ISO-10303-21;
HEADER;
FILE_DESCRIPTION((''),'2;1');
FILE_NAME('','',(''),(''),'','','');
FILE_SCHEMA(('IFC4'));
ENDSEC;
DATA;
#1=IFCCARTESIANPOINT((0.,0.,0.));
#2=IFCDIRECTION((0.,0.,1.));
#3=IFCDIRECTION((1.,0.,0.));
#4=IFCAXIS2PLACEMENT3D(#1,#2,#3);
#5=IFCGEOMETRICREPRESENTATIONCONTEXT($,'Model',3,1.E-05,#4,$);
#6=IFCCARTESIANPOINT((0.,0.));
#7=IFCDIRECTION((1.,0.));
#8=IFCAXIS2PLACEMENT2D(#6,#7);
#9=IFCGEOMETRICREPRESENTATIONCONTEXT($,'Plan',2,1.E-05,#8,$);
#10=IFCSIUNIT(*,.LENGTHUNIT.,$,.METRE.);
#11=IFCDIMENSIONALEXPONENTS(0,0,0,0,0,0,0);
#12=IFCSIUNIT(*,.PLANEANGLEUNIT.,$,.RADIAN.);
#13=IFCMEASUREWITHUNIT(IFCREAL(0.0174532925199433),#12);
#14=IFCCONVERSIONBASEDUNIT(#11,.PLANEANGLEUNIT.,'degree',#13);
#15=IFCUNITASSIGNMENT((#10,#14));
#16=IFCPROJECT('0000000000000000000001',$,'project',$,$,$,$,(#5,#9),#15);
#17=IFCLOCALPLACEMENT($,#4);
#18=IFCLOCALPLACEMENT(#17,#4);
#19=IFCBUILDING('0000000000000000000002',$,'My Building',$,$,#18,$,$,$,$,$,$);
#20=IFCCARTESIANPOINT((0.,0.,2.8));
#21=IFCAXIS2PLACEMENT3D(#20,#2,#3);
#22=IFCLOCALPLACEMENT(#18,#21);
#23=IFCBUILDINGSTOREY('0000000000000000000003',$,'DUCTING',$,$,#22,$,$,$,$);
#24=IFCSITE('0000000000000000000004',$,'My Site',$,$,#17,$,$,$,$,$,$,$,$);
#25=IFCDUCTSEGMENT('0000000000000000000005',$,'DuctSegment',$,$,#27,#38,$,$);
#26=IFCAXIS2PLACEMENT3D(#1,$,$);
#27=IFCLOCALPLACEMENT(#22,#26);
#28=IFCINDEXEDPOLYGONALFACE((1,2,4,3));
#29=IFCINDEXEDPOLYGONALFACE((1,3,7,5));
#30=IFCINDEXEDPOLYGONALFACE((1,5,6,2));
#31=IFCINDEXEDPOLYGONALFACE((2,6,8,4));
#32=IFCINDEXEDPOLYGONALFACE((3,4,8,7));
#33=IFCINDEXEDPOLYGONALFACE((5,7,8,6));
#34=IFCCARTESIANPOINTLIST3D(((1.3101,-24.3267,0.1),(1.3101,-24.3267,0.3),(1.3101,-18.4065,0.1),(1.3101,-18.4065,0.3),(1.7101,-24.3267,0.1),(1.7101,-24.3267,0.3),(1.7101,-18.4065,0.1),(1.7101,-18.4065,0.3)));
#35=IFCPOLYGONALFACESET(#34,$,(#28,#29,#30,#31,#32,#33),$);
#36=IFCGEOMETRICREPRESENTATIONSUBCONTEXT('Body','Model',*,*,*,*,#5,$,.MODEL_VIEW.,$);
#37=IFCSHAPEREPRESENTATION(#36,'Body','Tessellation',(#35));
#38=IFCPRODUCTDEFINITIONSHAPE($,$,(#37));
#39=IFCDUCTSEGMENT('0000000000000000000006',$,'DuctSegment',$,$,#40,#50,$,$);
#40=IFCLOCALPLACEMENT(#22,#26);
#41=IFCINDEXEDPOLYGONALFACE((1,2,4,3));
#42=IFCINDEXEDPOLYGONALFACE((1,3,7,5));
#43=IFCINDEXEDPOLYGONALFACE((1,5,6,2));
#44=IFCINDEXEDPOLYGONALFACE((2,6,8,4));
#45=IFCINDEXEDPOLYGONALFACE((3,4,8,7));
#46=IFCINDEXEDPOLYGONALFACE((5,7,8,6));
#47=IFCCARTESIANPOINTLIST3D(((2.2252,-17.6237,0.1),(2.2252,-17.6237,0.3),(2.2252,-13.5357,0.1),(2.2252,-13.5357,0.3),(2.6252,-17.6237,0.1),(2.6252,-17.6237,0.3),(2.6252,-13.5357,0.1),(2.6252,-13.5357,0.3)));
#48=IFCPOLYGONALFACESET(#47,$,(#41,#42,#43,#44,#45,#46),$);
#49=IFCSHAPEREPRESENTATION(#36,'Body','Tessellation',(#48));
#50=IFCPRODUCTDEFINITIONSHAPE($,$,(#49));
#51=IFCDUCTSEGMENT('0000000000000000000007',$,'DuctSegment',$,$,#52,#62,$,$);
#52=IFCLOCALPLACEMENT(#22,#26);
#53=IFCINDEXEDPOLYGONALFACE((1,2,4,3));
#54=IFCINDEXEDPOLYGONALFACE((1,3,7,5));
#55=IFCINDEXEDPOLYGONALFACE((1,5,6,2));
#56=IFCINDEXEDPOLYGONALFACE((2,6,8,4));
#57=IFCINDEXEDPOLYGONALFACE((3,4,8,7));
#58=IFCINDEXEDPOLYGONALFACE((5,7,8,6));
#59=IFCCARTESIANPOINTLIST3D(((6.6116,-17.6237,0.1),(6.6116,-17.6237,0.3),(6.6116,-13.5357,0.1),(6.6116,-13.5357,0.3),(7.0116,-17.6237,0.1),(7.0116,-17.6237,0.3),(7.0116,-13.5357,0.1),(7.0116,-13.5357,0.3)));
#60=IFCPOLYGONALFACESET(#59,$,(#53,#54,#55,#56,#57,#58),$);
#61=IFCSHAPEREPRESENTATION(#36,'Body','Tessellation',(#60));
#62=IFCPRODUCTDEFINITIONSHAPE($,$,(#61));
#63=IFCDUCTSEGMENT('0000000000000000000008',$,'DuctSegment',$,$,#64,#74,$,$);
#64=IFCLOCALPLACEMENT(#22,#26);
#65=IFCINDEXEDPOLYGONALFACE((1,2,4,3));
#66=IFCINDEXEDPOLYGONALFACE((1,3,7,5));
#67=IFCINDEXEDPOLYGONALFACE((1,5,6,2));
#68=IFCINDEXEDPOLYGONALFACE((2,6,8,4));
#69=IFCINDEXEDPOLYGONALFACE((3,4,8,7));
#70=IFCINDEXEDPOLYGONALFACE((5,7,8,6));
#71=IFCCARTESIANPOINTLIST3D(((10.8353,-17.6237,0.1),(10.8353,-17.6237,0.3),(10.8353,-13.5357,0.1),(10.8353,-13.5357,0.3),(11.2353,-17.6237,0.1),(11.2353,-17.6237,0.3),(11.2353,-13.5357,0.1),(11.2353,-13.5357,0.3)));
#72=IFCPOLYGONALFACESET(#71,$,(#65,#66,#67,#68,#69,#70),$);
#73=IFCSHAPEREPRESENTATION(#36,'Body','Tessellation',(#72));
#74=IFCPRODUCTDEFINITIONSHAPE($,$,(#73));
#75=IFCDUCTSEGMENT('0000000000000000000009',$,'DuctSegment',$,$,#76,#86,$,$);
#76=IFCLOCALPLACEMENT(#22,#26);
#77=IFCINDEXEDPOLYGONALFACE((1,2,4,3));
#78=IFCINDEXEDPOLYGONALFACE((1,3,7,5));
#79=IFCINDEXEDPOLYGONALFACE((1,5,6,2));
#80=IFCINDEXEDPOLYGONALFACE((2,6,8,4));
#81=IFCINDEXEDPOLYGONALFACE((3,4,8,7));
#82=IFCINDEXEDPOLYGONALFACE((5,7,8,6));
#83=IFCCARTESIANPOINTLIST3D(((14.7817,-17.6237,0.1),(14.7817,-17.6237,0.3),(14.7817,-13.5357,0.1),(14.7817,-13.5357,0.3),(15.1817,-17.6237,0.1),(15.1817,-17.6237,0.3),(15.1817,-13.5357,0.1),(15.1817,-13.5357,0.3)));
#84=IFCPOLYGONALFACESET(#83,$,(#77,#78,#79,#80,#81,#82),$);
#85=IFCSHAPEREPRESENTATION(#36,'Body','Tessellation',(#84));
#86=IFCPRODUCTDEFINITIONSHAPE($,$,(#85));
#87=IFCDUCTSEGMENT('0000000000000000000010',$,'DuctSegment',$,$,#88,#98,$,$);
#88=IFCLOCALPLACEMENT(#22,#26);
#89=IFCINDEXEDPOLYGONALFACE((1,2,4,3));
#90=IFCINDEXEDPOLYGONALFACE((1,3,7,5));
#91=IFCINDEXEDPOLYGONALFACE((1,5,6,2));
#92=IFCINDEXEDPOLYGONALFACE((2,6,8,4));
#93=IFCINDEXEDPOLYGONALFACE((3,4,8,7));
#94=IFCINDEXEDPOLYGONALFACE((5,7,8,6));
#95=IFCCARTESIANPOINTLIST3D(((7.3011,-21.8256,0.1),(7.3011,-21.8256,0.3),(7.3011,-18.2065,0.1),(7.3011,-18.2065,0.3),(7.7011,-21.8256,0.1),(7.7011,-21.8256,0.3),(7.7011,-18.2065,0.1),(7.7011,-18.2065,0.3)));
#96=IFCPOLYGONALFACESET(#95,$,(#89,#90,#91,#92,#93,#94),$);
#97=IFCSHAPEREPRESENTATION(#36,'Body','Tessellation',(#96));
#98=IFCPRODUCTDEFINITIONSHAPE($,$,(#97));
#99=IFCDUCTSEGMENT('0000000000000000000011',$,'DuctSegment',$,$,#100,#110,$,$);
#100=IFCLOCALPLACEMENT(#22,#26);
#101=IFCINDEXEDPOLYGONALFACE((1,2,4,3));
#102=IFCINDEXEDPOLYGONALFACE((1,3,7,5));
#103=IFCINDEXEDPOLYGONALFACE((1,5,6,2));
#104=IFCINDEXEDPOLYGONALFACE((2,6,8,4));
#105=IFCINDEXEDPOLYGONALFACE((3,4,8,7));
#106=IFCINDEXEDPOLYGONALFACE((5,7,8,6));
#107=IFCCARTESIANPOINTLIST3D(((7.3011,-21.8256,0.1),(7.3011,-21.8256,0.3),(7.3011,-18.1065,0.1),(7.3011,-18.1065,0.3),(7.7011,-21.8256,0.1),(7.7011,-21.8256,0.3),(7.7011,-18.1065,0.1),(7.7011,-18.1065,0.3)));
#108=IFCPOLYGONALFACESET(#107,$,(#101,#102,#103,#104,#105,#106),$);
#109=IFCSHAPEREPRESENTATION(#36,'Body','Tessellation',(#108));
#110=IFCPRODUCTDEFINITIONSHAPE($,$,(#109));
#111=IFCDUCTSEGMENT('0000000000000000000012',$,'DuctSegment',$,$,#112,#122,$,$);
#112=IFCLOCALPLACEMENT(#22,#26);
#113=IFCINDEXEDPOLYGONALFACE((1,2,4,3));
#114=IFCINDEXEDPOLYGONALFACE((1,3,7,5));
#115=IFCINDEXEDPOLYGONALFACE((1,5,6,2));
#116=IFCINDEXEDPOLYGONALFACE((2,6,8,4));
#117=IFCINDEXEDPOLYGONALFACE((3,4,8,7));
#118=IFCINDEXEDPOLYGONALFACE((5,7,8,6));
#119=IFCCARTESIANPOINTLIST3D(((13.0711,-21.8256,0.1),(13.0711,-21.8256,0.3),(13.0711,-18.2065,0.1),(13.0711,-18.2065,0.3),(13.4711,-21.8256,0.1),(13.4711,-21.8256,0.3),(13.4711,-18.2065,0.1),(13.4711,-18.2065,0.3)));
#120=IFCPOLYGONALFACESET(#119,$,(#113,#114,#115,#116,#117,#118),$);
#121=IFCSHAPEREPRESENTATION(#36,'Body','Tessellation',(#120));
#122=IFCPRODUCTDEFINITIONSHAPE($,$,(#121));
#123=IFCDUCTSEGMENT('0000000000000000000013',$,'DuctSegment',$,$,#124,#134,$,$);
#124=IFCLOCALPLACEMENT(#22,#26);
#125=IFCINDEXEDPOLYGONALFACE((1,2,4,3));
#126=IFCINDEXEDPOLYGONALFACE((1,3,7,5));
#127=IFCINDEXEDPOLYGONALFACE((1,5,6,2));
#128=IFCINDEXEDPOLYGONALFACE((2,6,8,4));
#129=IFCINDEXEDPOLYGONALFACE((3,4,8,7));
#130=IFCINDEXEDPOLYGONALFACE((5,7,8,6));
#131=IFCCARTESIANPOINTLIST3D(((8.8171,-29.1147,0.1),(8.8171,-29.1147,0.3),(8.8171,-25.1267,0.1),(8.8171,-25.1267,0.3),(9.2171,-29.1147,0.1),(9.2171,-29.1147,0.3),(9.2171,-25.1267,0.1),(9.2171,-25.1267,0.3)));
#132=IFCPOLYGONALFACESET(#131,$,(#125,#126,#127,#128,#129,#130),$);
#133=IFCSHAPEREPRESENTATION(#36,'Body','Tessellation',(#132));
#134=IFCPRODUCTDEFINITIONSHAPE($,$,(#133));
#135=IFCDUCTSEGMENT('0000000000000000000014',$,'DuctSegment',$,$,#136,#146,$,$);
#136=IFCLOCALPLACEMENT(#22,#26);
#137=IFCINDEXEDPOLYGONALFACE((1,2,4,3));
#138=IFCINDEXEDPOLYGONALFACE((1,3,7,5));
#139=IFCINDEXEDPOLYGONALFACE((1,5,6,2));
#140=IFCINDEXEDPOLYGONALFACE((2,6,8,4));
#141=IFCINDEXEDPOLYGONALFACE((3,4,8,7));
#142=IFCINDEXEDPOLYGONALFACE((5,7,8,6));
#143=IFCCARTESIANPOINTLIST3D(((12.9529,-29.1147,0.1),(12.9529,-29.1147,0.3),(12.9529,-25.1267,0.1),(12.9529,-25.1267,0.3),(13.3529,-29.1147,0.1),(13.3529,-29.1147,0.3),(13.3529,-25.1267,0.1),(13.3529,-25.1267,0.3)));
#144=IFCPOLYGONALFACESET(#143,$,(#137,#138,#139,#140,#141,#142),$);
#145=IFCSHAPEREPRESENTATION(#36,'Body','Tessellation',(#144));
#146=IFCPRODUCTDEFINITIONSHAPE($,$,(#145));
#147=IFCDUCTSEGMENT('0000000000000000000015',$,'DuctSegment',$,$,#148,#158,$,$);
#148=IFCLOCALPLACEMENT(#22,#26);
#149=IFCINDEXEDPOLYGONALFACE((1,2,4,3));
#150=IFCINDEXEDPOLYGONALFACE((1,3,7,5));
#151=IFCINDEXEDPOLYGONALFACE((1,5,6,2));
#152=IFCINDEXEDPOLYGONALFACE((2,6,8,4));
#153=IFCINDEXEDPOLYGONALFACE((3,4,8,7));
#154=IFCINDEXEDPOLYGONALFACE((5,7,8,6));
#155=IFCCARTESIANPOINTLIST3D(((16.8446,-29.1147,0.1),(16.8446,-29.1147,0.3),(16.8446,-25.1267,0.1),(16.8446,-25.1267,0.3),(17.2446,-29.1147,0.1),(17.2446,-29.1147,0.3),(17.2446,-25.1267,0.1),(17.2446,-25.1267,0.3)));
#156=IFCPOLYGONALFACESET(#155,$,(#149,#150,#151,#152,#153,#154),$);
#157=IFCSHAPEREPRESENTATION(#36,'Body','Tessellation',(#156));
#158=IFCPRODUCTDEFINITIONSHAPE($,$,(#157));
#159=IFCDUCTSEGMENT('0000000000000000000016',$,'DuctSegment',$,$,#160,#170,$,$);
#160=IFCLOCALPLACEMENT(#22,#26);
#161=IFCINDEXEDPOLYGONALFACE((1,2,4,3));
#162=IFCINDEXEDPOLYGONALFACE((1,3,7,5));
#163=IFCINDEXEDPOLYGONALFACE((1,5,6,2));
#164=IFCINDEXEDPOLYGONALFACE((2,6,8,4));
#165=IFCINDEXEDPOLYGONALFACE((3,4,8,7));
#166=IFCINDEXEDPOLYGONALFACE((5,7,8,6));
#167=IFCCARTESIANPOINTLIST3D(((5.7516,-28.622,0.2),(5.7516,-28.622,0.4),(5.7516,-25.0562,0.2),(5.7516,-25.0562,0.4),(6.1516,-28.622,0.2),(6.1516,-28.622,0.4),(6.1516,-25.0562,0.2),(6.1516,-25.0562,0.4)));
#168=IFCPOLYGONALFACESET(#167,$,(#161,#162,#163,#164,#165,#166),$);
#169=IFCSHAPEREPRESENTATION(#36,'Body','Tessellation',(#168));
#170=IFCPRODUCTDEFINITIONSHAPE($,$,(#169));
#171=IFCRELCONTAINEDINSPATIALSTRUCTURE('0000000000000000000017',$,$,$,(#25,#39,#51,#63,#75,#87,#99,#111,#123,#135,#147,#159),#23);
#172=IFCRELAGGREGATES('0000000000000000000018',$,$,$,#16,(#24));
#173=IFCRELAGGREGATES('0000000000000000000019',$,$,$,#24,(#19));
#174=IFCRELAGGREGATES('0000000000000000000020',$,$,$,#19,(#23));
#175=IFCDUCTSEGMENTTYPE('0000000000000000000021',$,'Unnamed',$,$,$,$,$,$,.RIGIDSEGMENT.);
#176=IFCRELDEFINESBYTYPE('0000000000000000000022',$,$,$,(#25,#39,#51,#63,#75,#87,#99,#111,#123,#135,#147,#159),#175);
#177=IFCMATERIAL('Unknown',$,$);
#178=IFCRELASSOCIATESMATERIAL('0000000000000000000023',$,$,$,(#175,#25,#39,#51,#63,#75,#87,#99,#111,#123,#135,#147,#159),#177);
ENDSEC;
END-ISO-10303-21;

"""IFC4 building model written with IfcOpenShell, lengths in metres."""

from ifc_helpers import new_model, entity, si_unit, converted_unit, frame, origin_with_axes, origin_2d_with_axis, place, context, subcontext, project, spatial, rectangle, extrude, material, material_profile, profile_set, profile_usage, type_object, element, save


model = new_model("IFC4")

# Units and contexts
model_context = context("Model", 3, precision=1e-05, world=origin_with_axes())
plan_context = context("Plan", 2, precision=1e-05, world=origin_2d_with_axis())
body_context = subcontext(model_context, "Body", "Model", "MODEL_VIEW")
ifc_project = project(units=[si_unit("LENGTHUNIT", "METRE"), converted_unit("PLANEANGLEUNIT", "degree", entity("IfcReal", 0.0174532925199433), si_unit("PLANEANGLEUNIT", "RADIAN"), dimensions=[0, 0, 0, 0, 0, 0, 0])], contexts=[model_context, plan_context])

# Site, building, storey
site_placement = place(None, origin_with_axes())
site = spatial("IfcSite", under=ifc_project, at=site_placement, Name="My Site")
building_placement = place(site_placement, origin_with_axes())
building = spatial("IfcBuilding", under=site, at=building_placement, Name="My Building")
storey_placement = place(building_placement, frame((0.0, 0.0, 2.8), z_axis=(0.0, 0.0, 1.0), x_axis=(1.0, 0.0, 0.0)))
storey = spatial("IfcBuildingStorey", under=building, at=storey_placement, Name="DUCTING")

# Duct segments
ifc_material = material(Name="Unknown")
ifc_material_profile_1 = material_profile(ifc_material, rectangle(XDim=0.4, YDim=0.2))
ifc_profile_set_1 = profile_set([ifc_material_profile_1])
ifc_profile_usage_1 = profile_usage(ifc_profile_set_1, cardinal=5)
duct_segment_type = type_object("IfcDuctSegmentType", Name="Unnamed", PredefinedType="RIGIDSEGMENT", material=ifc_profile_set_1)
duct_segment_1_placement = place(storey_placement, frame((1.5101, -18.4065, 0.2), z_axis=(0.0, -1.0, 0.0), x_axis=(1.0, 0.0, 0.0)))
element("IfcDuctSegment", 1, at=duct_segment_1_placement, inside=storey, type_object=duct_segment_type, material=ifc_profile_usage_1, Name="DuctSegment", context=body_context, shape_type="SweptSolid", body=[
    extrude(rectangle(XDim=0.4, YDim=0.2), origin_with_axes(), (0.0, 0.0, 1.0), 5.9202),
])
ifc_profile_usage_2 = profile_usage(ifc_profile_set_1, cardinal=5)
duct_segment_2_placement = place(storey_placement, frame((2.4252, -17.6237, 0.2), z_axis=(0.0, 1.0, 0.0), x_axis=(-1.0, 0.0, 0.0)))
element("IfcDuctSegment", 2, at=duct_segment_2_placement, inside=storey, type_object=duct_segment_type, material=ifc_profile_usage_2, Name="DuctSegment", context=body_context, shape_type="SweptSolid", body=[
    extrude(rectangle(XDim=0.4, YDim=0.2), origin_with_axes(), (0.0, 0.0, 1.0), 4.088),
])
ifc_profile_usage_3 = profile_usage(ifc_profile_set_1, cardinal=5)
duct_segment_3_placement = place(storey_placement, frame((6.8116, -17.6237, 0.2), z_axis=(0.0, 1.0, 0.0), x_axis=(-1.0, 0.0, 0.0)))
element("IfcDuctSegment", 3, at=duct_segment_3_placement, inside=storey, type_object=duct_segment_type, material=ifc_profile_usage_3, Name="DuctSegment", context=body_context, shape_type="SweptSolid", body=[
    extrude(rectangle(XDim=0.4, YDim=0.2), origin_with_axes(), (0.0, 0.0, 1.0), 4.088),
])
ifc_profile_usage_4 = profile_usage(ifc_profile_set_1, cardinal=5)
duct_segment_4_placement = place(storey_placement, frame((11.0353, -17.6237, 0.2), z_axis=(0.0, 1.0, 0.0), x_axis=(-1.0, 0.0, 0.0)))
element("IfcDuctSegment", 4, at=duct_segment_4_placement, inside=storey, type_object=duct_segment_type, material=ifc_profile_usage_4, Name="DuctSegment", context=body_context, shape_type="SweptSolid", body=[
    extrude(rectangle(XDim=0.4, YDim=0.2), origin_with_axes(), (0.0, 0.0, 1.0), 4.088),
])
ifc_profile_usage_5 = profile_usage(ifc_profile_set_1, cardinal=5)
duct_segment_5_placement = place(storey_placement, frame((14.9817, -17.6237, 0.2), z_axis=(0.0, 1.0, 0.0), x_axis=(-1.0, 0.0, 0.0)))
element("IfcDuctSegment", 5, at=duct_segment_5_placement, inside=storey, type_object=duct_segment_type, material=ifc_profile_usage_5, Name="DuctSegment", context=body_context, shape_type="SweptSolid", body=[
    extrude(rectangle(XDim=0.4, YDim=0.2), origin_with_axes(), (0.0, 0.0, 1.0), 4.088),
])
ifc_profile_usage_6 = profile_usage(ifc_profile_set_1, cardinal=5)
duct_segment_6_placement = place(storey_placement, frame((7.5011, -18.2065, 0.2), z_axis=(0.0, -1.0, 0.0), x_axis=(1.0, 0.0, 0.0)))
element("IfcDuctSegment", 6, at=duct_segment_6_placement, inside=storey, type_object=duct_segment_type, material=ifc_profile_usage_6, Name="DuctSegment", context=body_context, shape_type="SweptSolid", body=[
    extrude(rectangle(XDim=0.4, YDim=0.2), origin_with_axes(), (0.0, 0.0, 1.0), 3.6191),
])
ifc_profile_usage_7 = profile_usage(ifc_profile_set_1, cardinal=5)
duct_segment_7_placement = place(storey_placement, frame((7.5011, -18.1065, 0.2), z_axis=(0.0, -1.0, 0.0), x_axis=(1.0, 0.0, 0.0)))
element("IfcDuctSegment", 7, at=duct_segment_7_placement, inside=storey, type_object=duct_segment_type, material=ifc_profile_usage_7, Name="DuctSegment", context=body_context, shape_type="SweptSolid", body=[
    extrude(rectangle(XDim=0.4, YDim=0.2), origin_with_axes(), (0.0, 0.0, 1.0), 3.7191),
])
ifc_profile_usage_8 = profile_usage(ifc_profile_set_1, cardinal=5)
duct_segment_8_placement = place(storey_placement, frame((13.2711, -18.2065, 0.2), z_axis=(0.0, -1.0, 0.0), x_axis=(1.0, 0.0, 0.0)))
element("IfcDuctSegment", 8, at=duct_segment_8_placement, inside=storey, type_object=duct_segment_type, material=ifc_profile_usage_8, Name="DuctSegment", context=body_context, shape_type="SweptSolid", body=[
    extrude(rectangle(XDim=0.4, YDim=0.2), origin_with_axes(), (0.0, 0.0, 1.0), 3.6191),
])
ifc_profile_usage_9 = profile_usage(ifc_profile_set_1, cardinal=5)
duct_segment_9_placement = place(storey_placement, frame((9.0171, -25.1267, 0.2), z_axis=(0.0, -1.0, 0.0), x_axis=(1.0, 0.0, 0.0)))
element("IfcDuctSegment", 9, at=duct_segment_9_placement, inside=storey, type_object=duct_segment_type, material=ifc_profile_usage_9, Name="DuctSegment", context=body_context, shape_type="SweptSolid", body=[
    extrude(rectangle(XDim=0.4, YDim=0.2), origin_with_axes(), (0.0, 0.0, 1.0), 3.988),
])
ifc_profile_usage_10 = profile_usage(ifc_profile_set_1, cardinal=5)
duct_segment_10_placement = place(storey_placement, frame((13.1529, -25.1267, 0.2), z_axis=(0.0, -1.0, 0.0), x_axis=(1.0, 0.0, 0.0)))
element("IfcDuctSegment", 10, at=duct_segment_10_placement, inside=storey, type_object=duct_segment_type, material=ifc_profile_usage_10, Name="DuctSegment", context=body_context, shape_type="SweptSolid", body=[
    extrude(rectangle(XDim=0.4, YDim=0.2), origin_with_axes(), (0.0, 0.0, 1.0), 3.988),
])
ifc_profile_usage_11 = profile_usage(ifc_profile_set_1, cardinal=5)
duct_segment_11_placement = place(storey_placement, frame((17.0446, -25.1267, 0.2), z_axis=(0.0, -1.0, 0.0), x_axis=(1.0, 0.0, 0.0)))
element("IfcDuctSegment", 11, at=duct_segment_11_placement, inside=storey, type_object=duct_segment_type, material=ifc_profile_usage_11, Name="DuctSegment", context=body_context, shape_type="SweptSolid", body=[
    extrude(rectangle(XDim=0.4, YDim=0.2), origin_with_axes(), (0.0, 0.0, 1.0), 3.988),
])
ifc_profile_usage_12 = profile_usage(ifc_profile_set_1, cardinal=5)
duct_segment_12_placement = place(storey_placement, frame((5.9516, -25.0562, 0.3), z_axis=(0.0, -1.0, 0.0), x_axis=(1.0, 0.0, 0.0)))
element("IfcDuctSegment", 12, at=duct_segment_12_placement, inside=storey, type_object=duct_segment_type, material=ifc_profile_usage_12, Name="DuctSegment", context=body_context, shape_type="SweptSolid", body=[
    extrude(rectangle(XDim=0.4, YDim=0.2), origin_with_axes(), (0.0, 0.0, 1.0), 3.5659),
])

save(model, "model.ifc")
